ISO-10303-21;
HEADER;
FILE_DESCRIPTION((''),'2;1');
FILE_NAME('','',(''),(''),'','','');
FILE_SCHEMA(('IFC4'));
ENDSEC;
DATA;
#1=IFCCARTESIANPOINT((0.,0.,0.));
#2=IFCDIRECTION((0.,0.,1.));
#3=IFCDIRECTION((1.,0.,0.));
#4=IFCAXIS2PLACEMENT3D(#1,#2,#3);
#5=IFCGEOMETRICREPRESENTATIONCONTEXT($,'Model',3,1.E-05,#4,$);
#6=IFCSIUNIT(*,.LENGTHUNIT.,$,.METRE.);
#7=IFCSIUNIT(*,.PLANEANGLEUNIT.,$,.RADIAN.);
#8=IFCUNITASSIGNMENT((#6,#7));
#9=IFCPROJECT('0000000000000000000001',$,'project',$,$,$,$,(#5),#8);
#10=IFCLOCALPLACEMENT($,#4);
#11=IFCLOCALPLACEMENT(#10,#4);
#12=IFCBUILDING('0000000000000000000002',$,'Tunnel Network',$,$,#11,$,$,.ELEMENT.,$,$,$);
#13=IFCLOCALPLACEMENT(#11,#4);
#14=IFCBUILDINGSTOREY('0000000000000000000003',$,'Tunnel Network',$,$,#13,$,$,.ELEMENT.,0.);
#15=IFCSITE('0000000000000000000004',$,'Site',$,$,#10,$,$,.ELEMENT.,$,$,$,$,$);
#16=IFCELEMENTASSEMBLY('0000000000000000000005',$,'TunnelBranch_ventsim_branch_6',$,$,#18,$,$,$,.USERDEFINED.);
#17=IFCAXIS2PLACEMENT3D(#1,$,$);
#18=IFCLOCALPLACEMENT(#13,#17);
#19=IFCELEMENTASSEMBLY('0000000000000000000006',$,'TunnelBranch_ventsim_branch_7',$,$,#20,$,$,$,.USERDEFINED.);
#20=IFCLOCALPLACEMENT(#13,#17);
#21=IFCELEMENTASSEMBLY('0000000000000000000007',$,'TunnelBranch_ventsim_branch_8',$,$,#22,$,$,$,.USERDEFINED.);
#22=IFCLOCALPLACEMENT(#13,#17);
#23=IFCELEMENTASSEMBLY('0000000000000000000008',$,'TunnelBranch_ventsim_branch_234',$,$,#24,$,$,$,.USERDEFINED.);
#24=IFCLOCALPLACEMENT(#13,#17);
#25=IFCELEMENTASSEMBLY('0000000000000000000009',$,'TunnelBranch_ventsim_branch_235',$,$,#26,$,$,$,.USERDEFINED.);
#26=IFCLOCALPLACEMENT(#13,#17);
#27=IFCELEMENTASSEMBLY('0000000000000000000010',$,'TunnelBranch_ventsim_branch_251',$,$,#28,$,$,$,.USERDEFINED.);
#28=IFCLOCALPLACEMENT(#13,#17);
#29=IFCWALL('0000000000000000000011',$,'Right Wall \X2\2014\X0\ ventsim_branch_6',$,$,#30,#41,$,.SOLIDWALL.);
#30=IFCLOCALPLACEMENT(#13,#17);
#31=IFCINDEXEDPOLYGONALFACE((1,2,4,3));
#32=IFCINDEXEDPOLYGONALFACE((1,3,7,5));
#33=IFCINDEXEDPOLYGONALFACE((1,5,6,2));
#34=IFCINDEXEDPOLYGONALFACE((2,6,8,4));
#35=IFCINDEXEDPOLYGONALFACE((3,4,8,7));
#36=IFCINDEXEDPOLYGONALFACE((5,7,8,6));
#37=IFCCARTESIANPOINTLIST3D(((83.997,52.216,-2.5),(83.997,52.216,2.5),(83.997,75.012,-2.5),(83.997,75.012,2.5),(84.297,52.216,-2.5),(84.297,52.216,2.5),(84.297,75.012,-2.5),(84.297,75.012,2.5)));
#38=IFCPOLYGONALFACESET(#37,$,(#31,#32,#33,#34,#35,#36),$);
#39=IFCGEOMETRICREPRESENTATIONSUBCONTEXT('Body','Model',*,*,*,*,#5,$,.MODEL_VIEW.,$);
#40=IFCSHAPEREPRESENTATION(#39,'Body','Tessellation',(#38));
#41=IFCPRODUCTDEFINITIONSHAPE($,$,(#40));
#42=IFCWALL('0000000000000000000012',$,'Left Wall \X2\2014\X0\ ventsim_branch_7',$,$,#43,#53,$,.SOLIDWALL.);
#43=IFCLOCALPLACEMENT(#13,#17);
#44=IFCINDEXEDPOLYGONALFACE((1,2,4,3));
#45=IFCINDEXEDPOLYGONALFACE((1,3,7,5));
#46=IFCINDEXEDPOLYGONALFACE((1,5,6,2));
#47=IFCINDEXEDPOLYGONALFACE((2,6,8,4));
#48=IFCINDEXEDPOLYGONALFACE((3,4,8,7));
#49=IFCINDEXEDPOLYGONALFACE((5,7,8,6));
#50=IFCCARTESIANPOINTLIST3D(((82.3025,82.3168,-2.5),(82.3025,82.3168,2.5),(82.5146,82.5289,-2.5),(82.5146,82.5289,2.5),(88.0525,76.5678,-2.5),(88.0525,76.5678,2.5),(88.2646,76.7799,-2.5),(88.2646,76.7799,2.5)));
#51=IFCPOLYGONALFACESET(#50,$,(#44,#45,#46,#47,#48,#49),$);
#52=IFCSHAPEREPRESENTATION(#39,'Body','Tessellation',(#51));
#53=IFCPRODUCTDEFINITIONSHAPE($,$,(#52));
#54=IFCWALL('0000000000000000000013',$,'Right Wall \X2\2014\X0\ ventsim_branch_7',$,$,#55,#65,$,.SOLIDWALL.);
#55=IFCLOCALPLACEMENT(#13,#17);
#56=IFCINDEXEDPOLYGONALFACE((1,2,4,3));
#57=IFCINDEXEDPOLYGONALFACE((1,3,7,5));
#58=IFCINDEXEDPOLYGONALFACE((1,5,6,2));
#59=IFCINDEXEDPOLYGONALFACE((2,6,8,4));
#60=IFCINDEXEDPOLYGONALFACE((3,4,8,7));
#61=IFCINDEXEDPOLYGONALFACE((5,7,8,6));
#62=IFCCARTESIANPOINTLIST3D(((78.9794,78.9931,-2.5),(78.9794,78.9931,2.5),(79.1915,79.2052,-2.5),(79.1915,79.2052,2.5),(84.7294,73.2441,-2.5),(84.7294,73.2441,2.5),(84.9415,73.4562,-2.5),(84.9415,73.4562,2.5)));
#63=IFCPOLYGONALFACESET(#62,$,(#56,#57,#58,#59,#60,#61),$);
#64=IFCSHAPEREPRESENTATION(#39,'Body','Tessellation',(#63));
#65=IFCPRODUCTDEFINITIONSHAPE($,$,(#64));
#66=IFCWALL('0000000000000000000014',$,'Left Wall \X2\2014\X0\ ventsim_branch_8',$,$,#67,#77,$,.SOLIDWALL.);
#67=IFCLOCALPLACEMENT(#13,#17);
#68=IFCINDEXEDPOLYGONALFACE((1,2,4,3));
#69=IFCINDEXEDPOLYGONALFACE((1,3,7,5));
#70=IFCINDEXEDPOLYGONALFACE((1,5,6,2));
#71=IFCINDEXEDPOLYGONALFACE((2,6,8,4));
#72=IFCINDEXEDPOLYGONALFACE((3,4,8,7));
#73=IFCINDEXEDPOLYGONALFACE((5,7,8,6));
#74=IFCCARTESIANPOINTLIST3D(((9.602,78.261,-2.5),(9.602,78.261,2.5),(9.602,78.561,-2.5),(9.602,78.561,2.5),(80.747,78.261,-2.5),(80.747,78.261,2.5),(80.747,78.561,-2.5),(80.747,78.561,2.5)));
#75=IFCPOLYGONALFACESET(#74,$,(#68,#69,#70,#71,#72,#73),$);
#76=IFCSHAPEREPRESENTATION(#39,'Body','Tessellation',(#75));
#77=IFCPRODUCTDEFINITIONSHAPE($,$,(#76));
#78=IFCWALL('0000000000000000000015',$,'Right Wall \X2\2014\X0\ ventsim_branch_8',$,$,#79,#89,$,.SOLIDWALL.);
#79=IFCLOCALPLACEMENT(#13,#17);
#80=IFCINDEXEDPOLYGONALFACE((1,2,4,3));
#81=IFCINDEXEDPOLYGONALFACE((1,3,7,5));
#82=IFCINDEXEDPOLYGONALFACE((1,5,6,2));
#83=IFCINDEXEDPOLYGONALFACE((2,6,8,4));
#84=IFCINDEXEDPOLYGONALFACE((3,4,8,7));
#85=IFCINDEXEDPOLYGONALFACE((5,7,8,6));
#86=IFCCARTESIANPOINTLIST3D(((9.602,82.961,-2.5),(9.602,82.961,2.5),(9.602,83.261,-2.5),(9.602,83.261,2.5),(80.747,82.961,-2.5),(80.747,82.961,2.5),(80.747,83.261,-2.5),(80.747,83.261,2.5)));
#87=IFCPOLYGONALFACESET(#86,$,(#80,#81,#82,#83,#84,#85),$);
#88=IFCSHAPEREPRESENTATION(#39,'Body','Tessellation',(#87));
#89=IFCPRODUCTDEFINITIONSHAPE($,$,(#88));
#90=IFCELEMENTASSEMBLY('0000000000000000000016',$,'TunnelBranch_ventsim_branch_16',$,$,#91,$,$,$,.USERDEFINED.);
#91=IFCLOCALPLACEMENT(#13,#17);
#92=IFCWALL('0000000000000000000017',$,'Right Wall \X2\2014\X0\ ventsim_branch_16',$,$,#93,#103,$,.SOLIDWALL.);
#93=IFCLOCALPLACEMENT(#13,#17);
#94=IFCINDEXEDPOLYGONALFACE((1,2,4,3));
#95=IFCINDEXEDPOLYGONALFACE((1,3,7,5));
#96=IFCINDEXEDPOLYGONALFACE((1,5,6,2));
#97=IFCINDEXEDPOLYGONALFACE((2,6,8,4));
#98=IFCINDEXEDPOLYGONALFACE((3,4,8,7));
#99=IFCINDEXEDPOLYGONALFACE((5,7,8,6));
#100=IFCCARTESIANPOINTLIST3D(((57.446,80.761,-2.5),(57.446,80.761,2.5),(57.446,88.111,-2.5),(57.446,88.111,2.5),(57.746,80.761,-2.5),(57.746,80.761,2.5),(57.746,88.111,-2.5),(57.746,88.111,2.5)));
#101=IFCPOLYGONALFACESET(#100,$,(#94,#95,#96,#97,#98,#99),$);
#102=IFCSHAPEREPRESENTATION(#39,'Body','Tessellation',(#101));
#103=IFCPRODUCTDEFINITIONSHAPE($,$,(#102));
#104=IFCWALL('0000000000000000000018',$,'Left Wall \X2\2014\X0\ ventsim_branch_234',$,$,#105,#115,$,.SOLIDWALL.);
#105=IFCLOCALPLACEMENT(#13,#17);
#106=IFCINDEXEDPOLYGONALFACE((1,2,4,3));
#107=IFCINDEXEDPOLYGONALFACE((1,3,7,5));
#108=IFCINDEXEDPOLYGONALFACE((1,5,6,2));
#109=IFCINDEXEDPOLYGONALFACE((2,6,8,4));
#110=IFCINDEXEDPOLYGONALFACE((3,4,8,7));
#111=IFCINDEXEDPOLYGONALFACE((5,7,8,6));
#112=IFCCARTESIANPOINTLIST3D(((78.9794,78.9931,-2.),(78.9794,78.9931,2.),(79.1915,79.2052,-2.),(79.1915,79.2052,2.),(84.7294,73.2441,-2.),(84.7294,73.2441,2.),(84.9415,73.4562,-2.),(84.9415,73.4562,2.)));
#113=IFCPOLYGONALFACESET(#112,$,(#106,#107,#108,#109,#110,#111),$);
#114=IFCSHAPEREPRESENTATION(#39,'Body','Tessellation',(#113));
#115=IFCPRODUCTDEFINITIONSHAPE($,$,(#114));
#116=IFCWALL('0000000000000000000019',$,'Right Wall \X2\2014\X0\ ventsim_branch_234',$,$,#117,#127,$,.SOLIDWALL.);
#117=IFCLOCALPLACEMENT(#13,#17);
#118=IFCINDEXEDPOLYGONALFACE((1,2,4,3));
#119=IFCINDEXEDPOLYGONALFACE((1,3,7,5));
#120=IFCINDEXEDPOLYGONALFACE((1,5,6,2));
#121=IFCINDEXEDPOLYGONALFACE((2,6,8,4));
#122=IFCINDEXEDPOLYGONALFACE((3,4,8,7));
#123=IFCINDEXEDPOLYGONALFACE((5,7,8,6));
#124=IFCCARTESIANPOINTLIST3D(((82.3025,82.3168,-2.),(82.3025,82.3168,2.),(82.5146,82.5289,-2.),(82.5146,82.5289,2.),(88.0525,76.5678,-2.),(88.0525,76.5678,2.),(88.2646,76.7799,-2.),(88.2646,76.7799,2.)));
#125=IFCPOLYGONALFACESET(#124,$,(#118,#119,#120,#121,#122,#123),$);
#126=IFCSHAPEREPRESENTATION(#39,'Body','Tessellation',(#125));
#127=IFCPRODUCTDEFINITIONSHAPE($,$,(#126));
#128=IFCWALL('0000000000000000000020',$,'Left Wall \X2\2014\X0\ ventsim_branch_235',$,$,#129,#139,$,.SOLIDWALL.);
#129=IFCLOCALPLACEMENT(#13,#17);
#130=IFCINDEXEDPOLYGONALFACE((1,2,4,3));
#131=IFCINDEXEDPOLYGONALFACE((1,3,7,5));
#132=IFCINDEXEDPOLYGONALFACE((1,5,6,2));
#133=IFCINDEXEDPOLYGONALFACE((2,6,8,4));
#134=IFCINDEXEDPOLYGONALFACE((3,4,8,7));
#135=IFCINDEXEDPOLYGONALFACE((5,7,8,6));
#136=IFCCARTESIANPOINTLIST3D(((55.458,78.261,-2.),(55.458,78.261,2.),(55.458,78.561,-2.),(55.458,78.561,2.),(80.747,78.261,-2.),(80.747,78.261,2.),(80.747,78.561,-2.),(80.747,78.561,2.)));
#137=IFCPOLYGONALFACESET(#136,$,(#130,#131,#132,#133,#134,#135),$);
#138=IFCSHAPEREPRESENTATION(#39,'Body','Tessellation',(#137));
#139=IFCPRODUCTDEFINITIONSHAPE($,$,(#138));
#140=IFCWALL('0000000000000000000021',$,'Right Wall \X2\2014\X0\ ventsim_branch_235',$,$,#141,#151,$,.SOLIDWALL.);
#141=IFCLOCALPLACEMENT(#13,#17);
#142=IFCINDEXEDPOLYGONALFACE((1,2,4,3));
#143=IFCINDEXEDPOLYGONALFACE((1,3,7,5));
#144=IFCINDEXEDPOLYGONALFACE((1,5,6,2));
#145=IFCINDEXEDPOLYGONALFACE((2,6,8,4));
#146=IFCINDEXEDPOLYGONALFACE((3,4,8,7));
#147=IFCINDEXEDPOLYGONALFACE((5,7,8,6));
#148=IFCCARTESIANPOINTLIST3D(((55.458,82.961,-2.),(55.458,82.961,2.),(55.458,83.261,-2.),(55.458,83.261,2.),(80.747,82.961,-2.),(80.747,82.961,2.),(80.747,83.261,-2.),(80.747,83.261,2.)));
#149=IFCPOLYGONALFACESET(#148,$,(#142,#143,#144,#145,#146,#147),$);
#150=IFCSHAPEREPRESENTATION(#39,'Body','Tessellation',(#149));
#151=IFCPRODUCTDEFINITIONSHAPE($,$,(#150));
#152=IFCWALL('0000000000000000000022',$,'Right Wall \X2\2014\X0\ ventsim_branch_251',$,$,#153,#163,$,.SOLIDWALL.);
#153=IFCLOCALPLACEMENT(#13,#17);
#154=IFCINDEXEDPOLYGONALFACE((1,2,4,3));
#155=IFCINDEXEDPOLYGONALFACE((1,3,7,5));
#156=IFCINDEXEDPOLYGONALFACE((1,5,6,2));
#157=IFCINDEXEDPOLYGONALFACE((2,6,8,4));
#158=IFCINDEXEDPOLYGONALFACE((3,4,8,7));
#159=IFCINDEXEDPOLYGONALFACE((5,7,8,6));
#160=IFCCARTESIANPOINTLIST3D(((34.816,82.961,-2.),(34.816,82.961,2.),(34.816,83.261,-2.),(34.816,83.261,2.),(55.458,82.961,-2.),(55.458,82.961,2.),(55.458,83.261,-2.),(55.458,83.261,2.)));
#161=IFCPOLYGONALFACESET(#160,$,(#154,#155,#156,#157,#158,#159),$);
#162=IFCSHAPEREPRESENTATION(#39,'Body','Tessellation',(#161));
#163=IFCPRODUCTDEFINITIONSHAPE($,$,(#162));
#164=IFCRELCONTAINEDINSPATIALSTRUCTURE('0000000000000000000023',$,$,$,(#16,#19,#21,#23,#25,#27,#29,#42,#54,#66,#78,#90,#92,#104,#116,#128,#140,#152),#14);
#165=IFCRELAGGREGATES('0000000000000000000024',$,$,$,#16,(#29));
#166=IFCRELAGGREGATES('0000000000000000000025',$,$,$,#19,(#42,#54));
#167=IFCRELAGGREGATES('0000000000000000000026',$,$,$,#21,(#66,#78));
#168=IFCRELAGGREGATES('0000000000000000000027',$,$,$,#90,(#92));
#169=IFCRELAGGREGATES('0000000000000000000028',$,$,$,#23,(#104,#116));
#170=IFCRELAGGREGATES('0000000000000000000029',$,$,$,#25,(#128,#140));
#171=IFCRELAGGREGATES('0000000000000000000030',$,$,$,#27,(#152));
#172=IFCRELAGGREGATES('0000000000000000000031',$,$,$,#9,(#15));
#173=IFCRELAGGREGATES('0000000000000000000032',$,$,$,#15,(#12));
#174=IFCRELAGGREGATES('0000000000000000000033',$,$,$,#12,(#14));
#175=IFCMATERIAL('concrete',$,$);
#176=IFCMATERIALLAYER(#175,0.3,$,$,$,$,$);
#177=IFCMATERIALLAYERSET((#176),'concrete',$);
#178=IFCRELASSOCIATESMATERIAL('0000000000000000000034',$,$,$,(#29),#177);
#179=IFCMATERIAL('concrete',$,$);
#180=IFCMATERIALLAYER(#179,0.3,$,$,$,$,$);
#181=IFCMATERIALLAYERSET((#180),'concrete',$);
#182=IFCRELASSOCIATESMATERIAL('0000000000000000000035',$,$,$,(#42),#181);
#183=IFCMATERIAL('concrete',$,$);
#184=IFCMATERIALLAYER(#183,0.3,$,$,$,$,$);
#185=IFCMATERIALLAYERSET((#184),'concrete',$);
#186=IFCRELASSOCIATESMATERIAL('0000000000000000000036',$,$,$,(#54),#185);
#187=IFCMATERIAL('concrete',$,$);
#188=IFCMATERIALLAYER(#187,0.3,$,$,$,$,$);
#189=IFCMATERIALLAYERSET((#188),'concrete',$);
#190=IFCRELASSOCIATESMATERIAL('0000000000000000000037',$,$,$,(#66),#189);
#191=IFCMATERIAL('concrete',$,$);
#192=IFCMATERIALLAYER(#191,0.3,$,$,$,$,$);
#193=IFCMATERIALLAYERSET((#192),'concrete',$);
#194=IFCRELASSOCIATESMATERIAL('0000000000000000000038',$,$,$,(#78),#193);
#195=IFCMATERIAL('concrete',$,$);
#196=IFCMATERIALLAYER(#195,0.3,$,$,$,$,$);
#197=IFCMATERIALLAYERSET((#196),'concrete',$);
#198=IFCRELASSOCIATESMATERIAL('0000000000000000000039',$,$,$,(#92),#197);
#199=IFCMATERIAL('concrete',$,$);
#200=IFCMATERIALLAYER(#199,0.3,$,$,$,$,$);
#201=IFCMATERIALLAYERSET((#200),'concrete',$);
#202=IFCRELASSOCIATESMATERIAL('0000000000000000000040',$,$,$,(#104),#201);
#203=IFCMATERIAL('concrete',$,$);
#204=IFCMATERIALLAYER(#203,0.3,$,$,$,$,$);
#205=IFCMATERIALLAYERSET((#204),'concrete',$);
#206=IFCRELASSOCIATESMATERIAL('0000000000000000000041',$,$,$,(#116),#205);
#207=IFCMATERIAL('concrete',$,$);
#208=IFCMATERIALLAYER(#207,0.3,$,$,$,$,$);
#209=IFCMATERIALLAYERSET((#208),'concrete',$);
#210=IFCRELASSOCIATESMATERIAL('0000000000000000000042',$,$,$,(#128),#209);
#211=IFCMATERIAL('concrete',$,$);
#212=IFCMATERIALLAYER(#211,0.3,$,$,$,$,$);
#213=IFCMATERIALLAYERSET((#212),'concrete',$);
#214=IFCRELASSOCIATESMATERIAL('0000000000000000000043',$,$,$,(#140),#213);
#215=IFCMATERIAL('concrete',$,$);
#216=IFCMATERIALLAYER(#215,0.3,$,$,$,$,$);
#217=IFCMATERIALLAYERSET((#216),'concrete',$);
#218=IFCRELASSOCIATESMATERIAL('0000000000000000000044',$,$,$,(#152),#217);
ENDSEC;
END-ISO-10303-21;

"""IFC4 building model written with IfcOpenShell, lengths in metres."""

from ifc_helpers import new_model, si_unit, frame, origin_with_axes, origin_2d_with_axis, place, context, subcontext, project, spatial, rectangle, extrude, material, layer, layer_set, layer_usage, element, aggregate, save


model = new_model("IFC4")

# Units and contexts
model_context = context("Model", 3, precision=1e-05, world=origin_with_axes())
body_context = subcontext(model_context, "Body", "Model", "MODEL_VIEW")
ifc_project = project(units=[si_unit("LENGTHUNIT", "METRE"), si_unit("PLANEANGLEUNIT", "RADIAN")], contexts=[model_context])

# Site, building, storey
site_placement = place(None, origin_with_axes())
site = spatial("IfcSite", under=ifc_project, at=site_placement, Name="Site", CompositionType="ELEMENT")
building_placement = place(site_placement, origin_with_axes())
building = spatial("IfcBuilding", under=site, at=building_placement, Name="Tunnel Network", CompositionType="ELEMENT")
storey_placement = place(building_placement, origin_with_axes())
storey = spatial("IfcBuildingStorey", under=building, at=storey_placement, Name="Tunnel Network", CompositionType="ELEMENT", Elevation=0.0)

# Element assemblies
assembly_1_placement = place(storey_placement, frame((88.847, 75.012, 0.0), z_axis=(0.0, -1.0, 0.0), x_axis=(-1.0, 0.0, 0.0)))
assembly_1 = element("IfcElementAssembly", 1, at=assembly_1_placement, inside=storey, Name="TunnelBranch_ventsim_branch_6", PredefinedType="USERDEFINED")
assembly_2_placement = place(storey_placement, frame((82.4086, 82.4228, 0.0), z_axis=(0.707168, -0.707045, 0.0), x_axis=(-0.707045, -0.707168, 0.0)))
assembly_2 = element("IfcElementAssembly", 2, at=assembly_2_placement, inside=storey, Name="TunnelBranch_ventsim_branch_7", PredefinedType="USERDEFINED")
assembly_3_placement = place(storey_placement, frame((80.747, 78.411, 0.0), z_axis=(-1.0, 0.0, 0.0), x_axis=(0.0, 1.0, 0.0)))
assembly_3 = element("IfcElementAssembly", 3, at=assembly_3_placement, inside=storey, Name="TunnelBranch_ventsim_branch_8", PredefinedType="USERDEFINED")
assembly_4_placement = place(storey_placement, frame((84.8354, 73.3502, 0.0), z_axis=(-0.707168, 0.707045, 0.0), x_axis=(0.707045, 0.707168, 0.0)))
assembly_4 = element("IfcElementAssembly", 4, at=assembly_4_placement, inside=storey, Name="TunnelBranch_ventsim_branch_234", PredefinedType="USERDEFINED")
assembly_5_placement = place(storey_placement, frame((80.747, 78.411, 0.0), z_axis=(-1.0, 0.0, 0.0), x_axis=(0.0, 1.0, 0.0)))
assembly_5 = element("IfcElementAssembly", 5, at=assembly_5_placement, inside=storey, Name="TunnelBranch_ventsim_branch_235", PredefinedType="USERDEFINED")
assembly_6_placement = place(storey_placement, frame((55.458, 78.411, 0.0), z_axis=(-1.0, 0.0, 0.0), x_axis=(0.0, 1.0, 0.0)))
assembly_6 = element("IfcElementAssembly", 6, at=assembly_6_placement, inside=storey, Name="TunnelBranch_ventsim_branch_251", PredefinedType="USERDEFINED")

# Walls
ifc_material_1 = material(Name="concrete")
ifc_layer_1 = layer(ifc_material_1, 0.3)
ifc_layer_set_1 = layer_set([ifc_layer_1], Name="concrete")
ifc_layer_usage_1 = layer_usage(ifc_layer_set_1, "AXIS2", "POSITIVE", 0.0)
wall_1_placement = place(storey_placement, frame((84.147, 75.012, 0.0), z_axis=(0.0, -1.0, 0.0), x_axis=(-1.0, 0.0, 0.0)))
wall_1 = element("IfcWall", 7, at=wall_1_placement, inside=storey, material=ifc_layer_usage_1, Name="Right Wall — ventsim_branch_6", PredefinedType="SOLIDWALL", context=body_context, shape_type="SweptSolid", body=[
    extrude(rectangle(XDim=0.3, YDim=5.0, at=origin_2d_with_axis()), origin_with_axes(), (0.0, 0.0, 1.0), 22.796),
])
aggregate(assembly_1, [wall_1])
ifc_material_2 = material(Name="concrete")
ifc_layer_2 = layer(ifc_material_2, 0.3)
ifc_layer_set_2 = layer_set([ifc_layer_2], Name="concrete")
ifc_layer_usage_2 = layer_usage(ifc_layer_set_2, "AXIS2", "POSITIVE", 0.0)
wall_2_placement = place(storey_placement, frame((82.4086, 82.4228, 0.0), z_axis=(0.707168, -0.707045, 0.0), x_axis=(-0.707045, -0.707168, 0.0)))
wall_2 = element("IfcWall", 8, at=wall_2_placement, inside=storey, material=ifc_layer_usage_2, Name="Left Wall — ventsim_branch_7", PredefinedType="SOLIDWALL", context=body_context, shape_type="SweptSolid", body=[
    extrude(rectangle(XDim=0.3, YDim=5.0, at=origin_2d_with_axis()), origin_with_axes(), (0.0, 0.0, 1.0), 8.131),
])
ifc_material_3 = material(Name="concrete")
ifc_layer_3 = layer(ifc_material_3, 0.3)
ifc_layer_set_3 = layer_set([ifc_layer_3], Name="concrete")
ifc_layer_usage_3 = layer_usage(ifc_layer_set_3, "AXIS2", "POSITIVE", 0.0)
wall_3_placement = place(storey_placement, frame((79.0854, 79.0992, 0.0), z_axis=(0.707168, -0.707045, 0.0), x_axis=(-0.707045, -0.707168, 0.0)))
wall_3 = element("IfcWall", 9, at=wall_3_placement, inside=storey, material=ifc_layer_usage_3, Name="Right Wall — ventsim_branch_7", PredefinedType="SOLIDWALL", context=body_context, shape_type="SweptSolid", body=[
    extrude(rectangle(XDim=0.3, YDim=5.0, at=origin_2d_with_axis()), origin_with_axes(), (0.0, 0.0, 1.0), 8.131),
])
aggregate(assembly_2, [wall_2, wall_3])
ifc_material_4 = material(Name="concrete")
ifc_layer_4 = layer(ifc_material_4, 0.3)
ifc_layer_set_4 = layer_set([ifc_layer_4], Name="concrete")
ifc_layer_usage_4 = layer_usage(ifc_layer_set_4, "AXIS2", "POSITIVE", 0.0)
wall_4_placement = place(storey_placement, frame((80.747, 78.411, 0.0), z_axis=(-1.0, 0.0, 0.0), x_axis=(0.0, 1.0, 0.0)))
wall_4 = element("IfcWall", 10, at=wall_4_placement, inside=storey, material=ifc_layer_usage_4, Name="Left Wall — ventsim_branch_8", PredefinedType="SOLIDWALL", context=body_context, shape_type="SweptSolid", body=[
    extrude(rectangle(XDim=0.3, YDim=5.0, at=origin_2d_with_axis()), origin_with_axes(), (0.0, 0.0, 1.0), 71.145),
])
ifc_material_5 = material(Name="concrete")
ifc_layer_5 = layer(ifc_material_5, 0.3)
ifc_layer_set_5 = layer_set([ifc_layer_5], Name="concrete")
ifc_layer_usage_5 = layer_usage(ifc_layer_set_5, "AXIS2", "POSITIVE", 0.0)
wall_5_placement = place(storey_placement, frame((80.747, 83.111, 0.0), z_axis=(-1.0, 0.0, 0.0), x_axis=(0.0, 1.0, 0.0)))
wall_5 = element("IfcWall", 11, at=wall_5_placement, inside=storey, material=ifc_layer_usage_5, Name="Right Wall — ventsim_branch_8", PredefinedType="SOLIDWALL", context=body_context, shape_type="SweptSolid", body=[
    extrude(rectangle(XDim=0.3, YDim=5.0, at=origin_2d_with_axis()), origin_with_axes(), (0.0, 0.0, 1.0), 71.145),
])
aggregate(assembly_3, [wall_4, wall_5])

# Element assembly, wall
assembly_7_placement = place(storey_placement, frame((52.896, 80.761, 0.0), z_axis=(0.0, 1.0, 0.0), x_axis=(1.0, 0.0, 0.0)))
assembly_7 = element("IfcElementAssembly", 12, at=assembly_7_placement, inside=storey, Name="TunnelBranch_ventsim_branch_16", PredefinedType="USERDEFINED")
ifc_material_6 = material(Name="concrete")
ifc_layer_6 = layer(ifc_material_6, 0.3)
ifc_layer_set_6 = layer_set([ifc_layer_6], Name="concrete")
ifc_layer_usage_6 = layer_usage(ifc_layer_set_6, "AXIS2", "POSITIVE", 0.0)
wall_6_placement = place(storey_placement, frame((57.596, 80.761, 0.0), z_axis=(0.0, 1.0, 0.0), x_axis=(1.0, 0.0, 0.0)))
wall_6 = element("IfcWall", 13, at=wall_6_placement, inside=storey, material=ifc_layer_usage_6, Name="Right Wall — ventsim_branch_16", PredefinedType="SOLIDWALL", context=body_context, shape_type="SweptSolid", body=[
    extrude(rectangle(XDim=0.3, YDim=5.0, at=origin_2d_with_axis()), origin_with_axes(), (0.0, 0.0, 1.0), 7.35),
])
aggregate(assembly_7, [wall_6])

# Walls
ifc_material_7 = material(Name="concrete")
ifc_layer_7 = layer(ifc_material_7, 0.3)
ifc_layer_set_7 = layer_set([ifc_layer_7], Name="concrete")
ifc_layer_usage_7 = layer_usage(ifc_layer_set_7, "AXIS2", "POSITIVE", 0.0)
wall_7_placement = place(storey_placement, frame((84.8354, 73.3502, 0.0), z_axis=(-0.707168, 0.707045, 0.0), x_axis=(0.707045, 0.707168, 0.0)))
wall_7 = element("IfcWall", 14, at=wall_7_placement, inside=storey, material=ifc_layer_usage_7, Name="Left Wall — ventsim_branch_234", PredefinedType="SOLIDWALL", context=body_context, shape_type="SweptSolid", body=[
    extrude(rectangle(XDim=0.3, YDim=4.0, at=origin_2d_with_axis()), origin_with_axes(), (0.0, 0.0, 1.0), 8.131),
])
ifc_material_8 = material(Name="concrete")
ifc_layer_8 = layer(ifc_material_8, 0.3)
ifc_layer_set_8 = layer_set([ifc_layer_8], Name="concrete")
ifc_layer_usage_8 = layer_usage(ifc_layer_set_8, "AXIS2", "POSITIVE", 0.0)
wall_8_placement = place(storey_placement, frame((88.1586, 76.6738, 0.0), z_axis=(-0.707168, 0.707045, 0.0), x_axis=(0.707045, 0.707168, 0.0)))
wall_8 = element("IfcWall", 15, at=wall_8_placement, inside=storey, material=ifc_layer_usage_8, Name="Right Wall — ventsim_branch_234", PredefinedType="SOLIDWALL", context=body_context, shape_type="SweptSolid", body=[
    extrude(rectangle(XDim=0.3, YDim=4.0, at=origin_2d_with_axis()), origin_with_axes(), (0.0, 0.0, 1.0), 8.131),
])
aggregate(assembly_4, [wall_7, wall_8])
ifc_material_9 = material(Name="concrete")
ifc_layer_9 = layer(ifc_material_9, 0.3)
ifc_layer_set_9 = layer_set([ifc_layer_9], Name="concrete")
ifc_layer_usage_9 = layer_usage(ifc_layer_set_9, "AXIS2", "POSITIVE", 0.0)
wall_9_placement = place(storey_placement, frame((80.747, 78.411, 0.0), z_axis=(-1.0, 0.0, 0.0), x_axis=(0.0, 1.0, 0.0)))
wall_9 = element("IfcWall", 16, at=wall_9_placement, inside=storey, material=ifc_layer_usage_9, Name="Left Wall — ventsim_branch_235", PredefinedType="SOLIDWALL", context=body_context, shape_type="SweptSolid", body=[
    extrude(rectangle(XDim=0.3, YDim=4.0, at=origin_2d_with_axis()), origin_with_axes(), (0.0, 0.0, 1.0), 25.289),
])
ifc_material_10 = material(Name="concrete")
ifc_layer_10 = layer(ifc_material_10, 0.3)
ifc_layer_set_10 = layer_set([ifc_layer_10], Name="concrete")
ifc_layer_usage_10 = layer_usage(ifc_layer_set_10, "AXIS2", "POSITIVE", 0.0)
wall_10_placement = place(storey_placement, frame((80.747, 83.111, 0.0), z_axis=(-1.0, 0.0, 0.0), x_axis=(0.0, 1.0, 0.0)))
wall_10 = element("IfcWall", 17, at=wall_10_placement, inside=storey, material=ifc_layer_usage_10, Name="Right Wall — ventsim_branch_235", PredefinedType="SOLIDWALL", context=body_context, shape_type="SweptSolid", body=[
    extrude(rectangle(XDim=0.3, YDim=4.0, at=origin_2d_with_axis()), origin_with_axes(), (0.0, 0.0, 1.0), 25.289),
])
aggregate(assembly_5, [wall_9, wall_10])
ifc_material_11 = material(Name="concrete")
ifc_layer_11 = layer(ifc_material_11, 0.3)
ifc_layer_set_11 = layer_set([ifc_layer_11], Name="concrete")
ifc_layer_usage_11 = layer_usage(ifc_layer_set_11, "AXIS2", "POSITIVE", 0.0)
wall_11_placement = place(storey_placement, frame((55.458, 83.111, 0.0), z_axis=(-1.0, 0.0, 0.0), x_axis=(0.0, 1.0, 0.0)))
wall_11 = element("IfcWall", 18, at=wall_11_placement, inside=storey, material=ifc_layer_usage_11, Name="Right Wall — ventsim_branch_251", PredefinedType="SOLIDWALL", context=body_context, shape_type="SweptSolid", body=[
    extrude(rectangle(XDim=0.3, YDim=4.0, at=origin_2d_with_axis()), origin_with_axes(), (0.0, 0.0, 1.0), 20.642),
])
aggregate(assembly_6, [wall_11])

save(model, "model.ifc")
